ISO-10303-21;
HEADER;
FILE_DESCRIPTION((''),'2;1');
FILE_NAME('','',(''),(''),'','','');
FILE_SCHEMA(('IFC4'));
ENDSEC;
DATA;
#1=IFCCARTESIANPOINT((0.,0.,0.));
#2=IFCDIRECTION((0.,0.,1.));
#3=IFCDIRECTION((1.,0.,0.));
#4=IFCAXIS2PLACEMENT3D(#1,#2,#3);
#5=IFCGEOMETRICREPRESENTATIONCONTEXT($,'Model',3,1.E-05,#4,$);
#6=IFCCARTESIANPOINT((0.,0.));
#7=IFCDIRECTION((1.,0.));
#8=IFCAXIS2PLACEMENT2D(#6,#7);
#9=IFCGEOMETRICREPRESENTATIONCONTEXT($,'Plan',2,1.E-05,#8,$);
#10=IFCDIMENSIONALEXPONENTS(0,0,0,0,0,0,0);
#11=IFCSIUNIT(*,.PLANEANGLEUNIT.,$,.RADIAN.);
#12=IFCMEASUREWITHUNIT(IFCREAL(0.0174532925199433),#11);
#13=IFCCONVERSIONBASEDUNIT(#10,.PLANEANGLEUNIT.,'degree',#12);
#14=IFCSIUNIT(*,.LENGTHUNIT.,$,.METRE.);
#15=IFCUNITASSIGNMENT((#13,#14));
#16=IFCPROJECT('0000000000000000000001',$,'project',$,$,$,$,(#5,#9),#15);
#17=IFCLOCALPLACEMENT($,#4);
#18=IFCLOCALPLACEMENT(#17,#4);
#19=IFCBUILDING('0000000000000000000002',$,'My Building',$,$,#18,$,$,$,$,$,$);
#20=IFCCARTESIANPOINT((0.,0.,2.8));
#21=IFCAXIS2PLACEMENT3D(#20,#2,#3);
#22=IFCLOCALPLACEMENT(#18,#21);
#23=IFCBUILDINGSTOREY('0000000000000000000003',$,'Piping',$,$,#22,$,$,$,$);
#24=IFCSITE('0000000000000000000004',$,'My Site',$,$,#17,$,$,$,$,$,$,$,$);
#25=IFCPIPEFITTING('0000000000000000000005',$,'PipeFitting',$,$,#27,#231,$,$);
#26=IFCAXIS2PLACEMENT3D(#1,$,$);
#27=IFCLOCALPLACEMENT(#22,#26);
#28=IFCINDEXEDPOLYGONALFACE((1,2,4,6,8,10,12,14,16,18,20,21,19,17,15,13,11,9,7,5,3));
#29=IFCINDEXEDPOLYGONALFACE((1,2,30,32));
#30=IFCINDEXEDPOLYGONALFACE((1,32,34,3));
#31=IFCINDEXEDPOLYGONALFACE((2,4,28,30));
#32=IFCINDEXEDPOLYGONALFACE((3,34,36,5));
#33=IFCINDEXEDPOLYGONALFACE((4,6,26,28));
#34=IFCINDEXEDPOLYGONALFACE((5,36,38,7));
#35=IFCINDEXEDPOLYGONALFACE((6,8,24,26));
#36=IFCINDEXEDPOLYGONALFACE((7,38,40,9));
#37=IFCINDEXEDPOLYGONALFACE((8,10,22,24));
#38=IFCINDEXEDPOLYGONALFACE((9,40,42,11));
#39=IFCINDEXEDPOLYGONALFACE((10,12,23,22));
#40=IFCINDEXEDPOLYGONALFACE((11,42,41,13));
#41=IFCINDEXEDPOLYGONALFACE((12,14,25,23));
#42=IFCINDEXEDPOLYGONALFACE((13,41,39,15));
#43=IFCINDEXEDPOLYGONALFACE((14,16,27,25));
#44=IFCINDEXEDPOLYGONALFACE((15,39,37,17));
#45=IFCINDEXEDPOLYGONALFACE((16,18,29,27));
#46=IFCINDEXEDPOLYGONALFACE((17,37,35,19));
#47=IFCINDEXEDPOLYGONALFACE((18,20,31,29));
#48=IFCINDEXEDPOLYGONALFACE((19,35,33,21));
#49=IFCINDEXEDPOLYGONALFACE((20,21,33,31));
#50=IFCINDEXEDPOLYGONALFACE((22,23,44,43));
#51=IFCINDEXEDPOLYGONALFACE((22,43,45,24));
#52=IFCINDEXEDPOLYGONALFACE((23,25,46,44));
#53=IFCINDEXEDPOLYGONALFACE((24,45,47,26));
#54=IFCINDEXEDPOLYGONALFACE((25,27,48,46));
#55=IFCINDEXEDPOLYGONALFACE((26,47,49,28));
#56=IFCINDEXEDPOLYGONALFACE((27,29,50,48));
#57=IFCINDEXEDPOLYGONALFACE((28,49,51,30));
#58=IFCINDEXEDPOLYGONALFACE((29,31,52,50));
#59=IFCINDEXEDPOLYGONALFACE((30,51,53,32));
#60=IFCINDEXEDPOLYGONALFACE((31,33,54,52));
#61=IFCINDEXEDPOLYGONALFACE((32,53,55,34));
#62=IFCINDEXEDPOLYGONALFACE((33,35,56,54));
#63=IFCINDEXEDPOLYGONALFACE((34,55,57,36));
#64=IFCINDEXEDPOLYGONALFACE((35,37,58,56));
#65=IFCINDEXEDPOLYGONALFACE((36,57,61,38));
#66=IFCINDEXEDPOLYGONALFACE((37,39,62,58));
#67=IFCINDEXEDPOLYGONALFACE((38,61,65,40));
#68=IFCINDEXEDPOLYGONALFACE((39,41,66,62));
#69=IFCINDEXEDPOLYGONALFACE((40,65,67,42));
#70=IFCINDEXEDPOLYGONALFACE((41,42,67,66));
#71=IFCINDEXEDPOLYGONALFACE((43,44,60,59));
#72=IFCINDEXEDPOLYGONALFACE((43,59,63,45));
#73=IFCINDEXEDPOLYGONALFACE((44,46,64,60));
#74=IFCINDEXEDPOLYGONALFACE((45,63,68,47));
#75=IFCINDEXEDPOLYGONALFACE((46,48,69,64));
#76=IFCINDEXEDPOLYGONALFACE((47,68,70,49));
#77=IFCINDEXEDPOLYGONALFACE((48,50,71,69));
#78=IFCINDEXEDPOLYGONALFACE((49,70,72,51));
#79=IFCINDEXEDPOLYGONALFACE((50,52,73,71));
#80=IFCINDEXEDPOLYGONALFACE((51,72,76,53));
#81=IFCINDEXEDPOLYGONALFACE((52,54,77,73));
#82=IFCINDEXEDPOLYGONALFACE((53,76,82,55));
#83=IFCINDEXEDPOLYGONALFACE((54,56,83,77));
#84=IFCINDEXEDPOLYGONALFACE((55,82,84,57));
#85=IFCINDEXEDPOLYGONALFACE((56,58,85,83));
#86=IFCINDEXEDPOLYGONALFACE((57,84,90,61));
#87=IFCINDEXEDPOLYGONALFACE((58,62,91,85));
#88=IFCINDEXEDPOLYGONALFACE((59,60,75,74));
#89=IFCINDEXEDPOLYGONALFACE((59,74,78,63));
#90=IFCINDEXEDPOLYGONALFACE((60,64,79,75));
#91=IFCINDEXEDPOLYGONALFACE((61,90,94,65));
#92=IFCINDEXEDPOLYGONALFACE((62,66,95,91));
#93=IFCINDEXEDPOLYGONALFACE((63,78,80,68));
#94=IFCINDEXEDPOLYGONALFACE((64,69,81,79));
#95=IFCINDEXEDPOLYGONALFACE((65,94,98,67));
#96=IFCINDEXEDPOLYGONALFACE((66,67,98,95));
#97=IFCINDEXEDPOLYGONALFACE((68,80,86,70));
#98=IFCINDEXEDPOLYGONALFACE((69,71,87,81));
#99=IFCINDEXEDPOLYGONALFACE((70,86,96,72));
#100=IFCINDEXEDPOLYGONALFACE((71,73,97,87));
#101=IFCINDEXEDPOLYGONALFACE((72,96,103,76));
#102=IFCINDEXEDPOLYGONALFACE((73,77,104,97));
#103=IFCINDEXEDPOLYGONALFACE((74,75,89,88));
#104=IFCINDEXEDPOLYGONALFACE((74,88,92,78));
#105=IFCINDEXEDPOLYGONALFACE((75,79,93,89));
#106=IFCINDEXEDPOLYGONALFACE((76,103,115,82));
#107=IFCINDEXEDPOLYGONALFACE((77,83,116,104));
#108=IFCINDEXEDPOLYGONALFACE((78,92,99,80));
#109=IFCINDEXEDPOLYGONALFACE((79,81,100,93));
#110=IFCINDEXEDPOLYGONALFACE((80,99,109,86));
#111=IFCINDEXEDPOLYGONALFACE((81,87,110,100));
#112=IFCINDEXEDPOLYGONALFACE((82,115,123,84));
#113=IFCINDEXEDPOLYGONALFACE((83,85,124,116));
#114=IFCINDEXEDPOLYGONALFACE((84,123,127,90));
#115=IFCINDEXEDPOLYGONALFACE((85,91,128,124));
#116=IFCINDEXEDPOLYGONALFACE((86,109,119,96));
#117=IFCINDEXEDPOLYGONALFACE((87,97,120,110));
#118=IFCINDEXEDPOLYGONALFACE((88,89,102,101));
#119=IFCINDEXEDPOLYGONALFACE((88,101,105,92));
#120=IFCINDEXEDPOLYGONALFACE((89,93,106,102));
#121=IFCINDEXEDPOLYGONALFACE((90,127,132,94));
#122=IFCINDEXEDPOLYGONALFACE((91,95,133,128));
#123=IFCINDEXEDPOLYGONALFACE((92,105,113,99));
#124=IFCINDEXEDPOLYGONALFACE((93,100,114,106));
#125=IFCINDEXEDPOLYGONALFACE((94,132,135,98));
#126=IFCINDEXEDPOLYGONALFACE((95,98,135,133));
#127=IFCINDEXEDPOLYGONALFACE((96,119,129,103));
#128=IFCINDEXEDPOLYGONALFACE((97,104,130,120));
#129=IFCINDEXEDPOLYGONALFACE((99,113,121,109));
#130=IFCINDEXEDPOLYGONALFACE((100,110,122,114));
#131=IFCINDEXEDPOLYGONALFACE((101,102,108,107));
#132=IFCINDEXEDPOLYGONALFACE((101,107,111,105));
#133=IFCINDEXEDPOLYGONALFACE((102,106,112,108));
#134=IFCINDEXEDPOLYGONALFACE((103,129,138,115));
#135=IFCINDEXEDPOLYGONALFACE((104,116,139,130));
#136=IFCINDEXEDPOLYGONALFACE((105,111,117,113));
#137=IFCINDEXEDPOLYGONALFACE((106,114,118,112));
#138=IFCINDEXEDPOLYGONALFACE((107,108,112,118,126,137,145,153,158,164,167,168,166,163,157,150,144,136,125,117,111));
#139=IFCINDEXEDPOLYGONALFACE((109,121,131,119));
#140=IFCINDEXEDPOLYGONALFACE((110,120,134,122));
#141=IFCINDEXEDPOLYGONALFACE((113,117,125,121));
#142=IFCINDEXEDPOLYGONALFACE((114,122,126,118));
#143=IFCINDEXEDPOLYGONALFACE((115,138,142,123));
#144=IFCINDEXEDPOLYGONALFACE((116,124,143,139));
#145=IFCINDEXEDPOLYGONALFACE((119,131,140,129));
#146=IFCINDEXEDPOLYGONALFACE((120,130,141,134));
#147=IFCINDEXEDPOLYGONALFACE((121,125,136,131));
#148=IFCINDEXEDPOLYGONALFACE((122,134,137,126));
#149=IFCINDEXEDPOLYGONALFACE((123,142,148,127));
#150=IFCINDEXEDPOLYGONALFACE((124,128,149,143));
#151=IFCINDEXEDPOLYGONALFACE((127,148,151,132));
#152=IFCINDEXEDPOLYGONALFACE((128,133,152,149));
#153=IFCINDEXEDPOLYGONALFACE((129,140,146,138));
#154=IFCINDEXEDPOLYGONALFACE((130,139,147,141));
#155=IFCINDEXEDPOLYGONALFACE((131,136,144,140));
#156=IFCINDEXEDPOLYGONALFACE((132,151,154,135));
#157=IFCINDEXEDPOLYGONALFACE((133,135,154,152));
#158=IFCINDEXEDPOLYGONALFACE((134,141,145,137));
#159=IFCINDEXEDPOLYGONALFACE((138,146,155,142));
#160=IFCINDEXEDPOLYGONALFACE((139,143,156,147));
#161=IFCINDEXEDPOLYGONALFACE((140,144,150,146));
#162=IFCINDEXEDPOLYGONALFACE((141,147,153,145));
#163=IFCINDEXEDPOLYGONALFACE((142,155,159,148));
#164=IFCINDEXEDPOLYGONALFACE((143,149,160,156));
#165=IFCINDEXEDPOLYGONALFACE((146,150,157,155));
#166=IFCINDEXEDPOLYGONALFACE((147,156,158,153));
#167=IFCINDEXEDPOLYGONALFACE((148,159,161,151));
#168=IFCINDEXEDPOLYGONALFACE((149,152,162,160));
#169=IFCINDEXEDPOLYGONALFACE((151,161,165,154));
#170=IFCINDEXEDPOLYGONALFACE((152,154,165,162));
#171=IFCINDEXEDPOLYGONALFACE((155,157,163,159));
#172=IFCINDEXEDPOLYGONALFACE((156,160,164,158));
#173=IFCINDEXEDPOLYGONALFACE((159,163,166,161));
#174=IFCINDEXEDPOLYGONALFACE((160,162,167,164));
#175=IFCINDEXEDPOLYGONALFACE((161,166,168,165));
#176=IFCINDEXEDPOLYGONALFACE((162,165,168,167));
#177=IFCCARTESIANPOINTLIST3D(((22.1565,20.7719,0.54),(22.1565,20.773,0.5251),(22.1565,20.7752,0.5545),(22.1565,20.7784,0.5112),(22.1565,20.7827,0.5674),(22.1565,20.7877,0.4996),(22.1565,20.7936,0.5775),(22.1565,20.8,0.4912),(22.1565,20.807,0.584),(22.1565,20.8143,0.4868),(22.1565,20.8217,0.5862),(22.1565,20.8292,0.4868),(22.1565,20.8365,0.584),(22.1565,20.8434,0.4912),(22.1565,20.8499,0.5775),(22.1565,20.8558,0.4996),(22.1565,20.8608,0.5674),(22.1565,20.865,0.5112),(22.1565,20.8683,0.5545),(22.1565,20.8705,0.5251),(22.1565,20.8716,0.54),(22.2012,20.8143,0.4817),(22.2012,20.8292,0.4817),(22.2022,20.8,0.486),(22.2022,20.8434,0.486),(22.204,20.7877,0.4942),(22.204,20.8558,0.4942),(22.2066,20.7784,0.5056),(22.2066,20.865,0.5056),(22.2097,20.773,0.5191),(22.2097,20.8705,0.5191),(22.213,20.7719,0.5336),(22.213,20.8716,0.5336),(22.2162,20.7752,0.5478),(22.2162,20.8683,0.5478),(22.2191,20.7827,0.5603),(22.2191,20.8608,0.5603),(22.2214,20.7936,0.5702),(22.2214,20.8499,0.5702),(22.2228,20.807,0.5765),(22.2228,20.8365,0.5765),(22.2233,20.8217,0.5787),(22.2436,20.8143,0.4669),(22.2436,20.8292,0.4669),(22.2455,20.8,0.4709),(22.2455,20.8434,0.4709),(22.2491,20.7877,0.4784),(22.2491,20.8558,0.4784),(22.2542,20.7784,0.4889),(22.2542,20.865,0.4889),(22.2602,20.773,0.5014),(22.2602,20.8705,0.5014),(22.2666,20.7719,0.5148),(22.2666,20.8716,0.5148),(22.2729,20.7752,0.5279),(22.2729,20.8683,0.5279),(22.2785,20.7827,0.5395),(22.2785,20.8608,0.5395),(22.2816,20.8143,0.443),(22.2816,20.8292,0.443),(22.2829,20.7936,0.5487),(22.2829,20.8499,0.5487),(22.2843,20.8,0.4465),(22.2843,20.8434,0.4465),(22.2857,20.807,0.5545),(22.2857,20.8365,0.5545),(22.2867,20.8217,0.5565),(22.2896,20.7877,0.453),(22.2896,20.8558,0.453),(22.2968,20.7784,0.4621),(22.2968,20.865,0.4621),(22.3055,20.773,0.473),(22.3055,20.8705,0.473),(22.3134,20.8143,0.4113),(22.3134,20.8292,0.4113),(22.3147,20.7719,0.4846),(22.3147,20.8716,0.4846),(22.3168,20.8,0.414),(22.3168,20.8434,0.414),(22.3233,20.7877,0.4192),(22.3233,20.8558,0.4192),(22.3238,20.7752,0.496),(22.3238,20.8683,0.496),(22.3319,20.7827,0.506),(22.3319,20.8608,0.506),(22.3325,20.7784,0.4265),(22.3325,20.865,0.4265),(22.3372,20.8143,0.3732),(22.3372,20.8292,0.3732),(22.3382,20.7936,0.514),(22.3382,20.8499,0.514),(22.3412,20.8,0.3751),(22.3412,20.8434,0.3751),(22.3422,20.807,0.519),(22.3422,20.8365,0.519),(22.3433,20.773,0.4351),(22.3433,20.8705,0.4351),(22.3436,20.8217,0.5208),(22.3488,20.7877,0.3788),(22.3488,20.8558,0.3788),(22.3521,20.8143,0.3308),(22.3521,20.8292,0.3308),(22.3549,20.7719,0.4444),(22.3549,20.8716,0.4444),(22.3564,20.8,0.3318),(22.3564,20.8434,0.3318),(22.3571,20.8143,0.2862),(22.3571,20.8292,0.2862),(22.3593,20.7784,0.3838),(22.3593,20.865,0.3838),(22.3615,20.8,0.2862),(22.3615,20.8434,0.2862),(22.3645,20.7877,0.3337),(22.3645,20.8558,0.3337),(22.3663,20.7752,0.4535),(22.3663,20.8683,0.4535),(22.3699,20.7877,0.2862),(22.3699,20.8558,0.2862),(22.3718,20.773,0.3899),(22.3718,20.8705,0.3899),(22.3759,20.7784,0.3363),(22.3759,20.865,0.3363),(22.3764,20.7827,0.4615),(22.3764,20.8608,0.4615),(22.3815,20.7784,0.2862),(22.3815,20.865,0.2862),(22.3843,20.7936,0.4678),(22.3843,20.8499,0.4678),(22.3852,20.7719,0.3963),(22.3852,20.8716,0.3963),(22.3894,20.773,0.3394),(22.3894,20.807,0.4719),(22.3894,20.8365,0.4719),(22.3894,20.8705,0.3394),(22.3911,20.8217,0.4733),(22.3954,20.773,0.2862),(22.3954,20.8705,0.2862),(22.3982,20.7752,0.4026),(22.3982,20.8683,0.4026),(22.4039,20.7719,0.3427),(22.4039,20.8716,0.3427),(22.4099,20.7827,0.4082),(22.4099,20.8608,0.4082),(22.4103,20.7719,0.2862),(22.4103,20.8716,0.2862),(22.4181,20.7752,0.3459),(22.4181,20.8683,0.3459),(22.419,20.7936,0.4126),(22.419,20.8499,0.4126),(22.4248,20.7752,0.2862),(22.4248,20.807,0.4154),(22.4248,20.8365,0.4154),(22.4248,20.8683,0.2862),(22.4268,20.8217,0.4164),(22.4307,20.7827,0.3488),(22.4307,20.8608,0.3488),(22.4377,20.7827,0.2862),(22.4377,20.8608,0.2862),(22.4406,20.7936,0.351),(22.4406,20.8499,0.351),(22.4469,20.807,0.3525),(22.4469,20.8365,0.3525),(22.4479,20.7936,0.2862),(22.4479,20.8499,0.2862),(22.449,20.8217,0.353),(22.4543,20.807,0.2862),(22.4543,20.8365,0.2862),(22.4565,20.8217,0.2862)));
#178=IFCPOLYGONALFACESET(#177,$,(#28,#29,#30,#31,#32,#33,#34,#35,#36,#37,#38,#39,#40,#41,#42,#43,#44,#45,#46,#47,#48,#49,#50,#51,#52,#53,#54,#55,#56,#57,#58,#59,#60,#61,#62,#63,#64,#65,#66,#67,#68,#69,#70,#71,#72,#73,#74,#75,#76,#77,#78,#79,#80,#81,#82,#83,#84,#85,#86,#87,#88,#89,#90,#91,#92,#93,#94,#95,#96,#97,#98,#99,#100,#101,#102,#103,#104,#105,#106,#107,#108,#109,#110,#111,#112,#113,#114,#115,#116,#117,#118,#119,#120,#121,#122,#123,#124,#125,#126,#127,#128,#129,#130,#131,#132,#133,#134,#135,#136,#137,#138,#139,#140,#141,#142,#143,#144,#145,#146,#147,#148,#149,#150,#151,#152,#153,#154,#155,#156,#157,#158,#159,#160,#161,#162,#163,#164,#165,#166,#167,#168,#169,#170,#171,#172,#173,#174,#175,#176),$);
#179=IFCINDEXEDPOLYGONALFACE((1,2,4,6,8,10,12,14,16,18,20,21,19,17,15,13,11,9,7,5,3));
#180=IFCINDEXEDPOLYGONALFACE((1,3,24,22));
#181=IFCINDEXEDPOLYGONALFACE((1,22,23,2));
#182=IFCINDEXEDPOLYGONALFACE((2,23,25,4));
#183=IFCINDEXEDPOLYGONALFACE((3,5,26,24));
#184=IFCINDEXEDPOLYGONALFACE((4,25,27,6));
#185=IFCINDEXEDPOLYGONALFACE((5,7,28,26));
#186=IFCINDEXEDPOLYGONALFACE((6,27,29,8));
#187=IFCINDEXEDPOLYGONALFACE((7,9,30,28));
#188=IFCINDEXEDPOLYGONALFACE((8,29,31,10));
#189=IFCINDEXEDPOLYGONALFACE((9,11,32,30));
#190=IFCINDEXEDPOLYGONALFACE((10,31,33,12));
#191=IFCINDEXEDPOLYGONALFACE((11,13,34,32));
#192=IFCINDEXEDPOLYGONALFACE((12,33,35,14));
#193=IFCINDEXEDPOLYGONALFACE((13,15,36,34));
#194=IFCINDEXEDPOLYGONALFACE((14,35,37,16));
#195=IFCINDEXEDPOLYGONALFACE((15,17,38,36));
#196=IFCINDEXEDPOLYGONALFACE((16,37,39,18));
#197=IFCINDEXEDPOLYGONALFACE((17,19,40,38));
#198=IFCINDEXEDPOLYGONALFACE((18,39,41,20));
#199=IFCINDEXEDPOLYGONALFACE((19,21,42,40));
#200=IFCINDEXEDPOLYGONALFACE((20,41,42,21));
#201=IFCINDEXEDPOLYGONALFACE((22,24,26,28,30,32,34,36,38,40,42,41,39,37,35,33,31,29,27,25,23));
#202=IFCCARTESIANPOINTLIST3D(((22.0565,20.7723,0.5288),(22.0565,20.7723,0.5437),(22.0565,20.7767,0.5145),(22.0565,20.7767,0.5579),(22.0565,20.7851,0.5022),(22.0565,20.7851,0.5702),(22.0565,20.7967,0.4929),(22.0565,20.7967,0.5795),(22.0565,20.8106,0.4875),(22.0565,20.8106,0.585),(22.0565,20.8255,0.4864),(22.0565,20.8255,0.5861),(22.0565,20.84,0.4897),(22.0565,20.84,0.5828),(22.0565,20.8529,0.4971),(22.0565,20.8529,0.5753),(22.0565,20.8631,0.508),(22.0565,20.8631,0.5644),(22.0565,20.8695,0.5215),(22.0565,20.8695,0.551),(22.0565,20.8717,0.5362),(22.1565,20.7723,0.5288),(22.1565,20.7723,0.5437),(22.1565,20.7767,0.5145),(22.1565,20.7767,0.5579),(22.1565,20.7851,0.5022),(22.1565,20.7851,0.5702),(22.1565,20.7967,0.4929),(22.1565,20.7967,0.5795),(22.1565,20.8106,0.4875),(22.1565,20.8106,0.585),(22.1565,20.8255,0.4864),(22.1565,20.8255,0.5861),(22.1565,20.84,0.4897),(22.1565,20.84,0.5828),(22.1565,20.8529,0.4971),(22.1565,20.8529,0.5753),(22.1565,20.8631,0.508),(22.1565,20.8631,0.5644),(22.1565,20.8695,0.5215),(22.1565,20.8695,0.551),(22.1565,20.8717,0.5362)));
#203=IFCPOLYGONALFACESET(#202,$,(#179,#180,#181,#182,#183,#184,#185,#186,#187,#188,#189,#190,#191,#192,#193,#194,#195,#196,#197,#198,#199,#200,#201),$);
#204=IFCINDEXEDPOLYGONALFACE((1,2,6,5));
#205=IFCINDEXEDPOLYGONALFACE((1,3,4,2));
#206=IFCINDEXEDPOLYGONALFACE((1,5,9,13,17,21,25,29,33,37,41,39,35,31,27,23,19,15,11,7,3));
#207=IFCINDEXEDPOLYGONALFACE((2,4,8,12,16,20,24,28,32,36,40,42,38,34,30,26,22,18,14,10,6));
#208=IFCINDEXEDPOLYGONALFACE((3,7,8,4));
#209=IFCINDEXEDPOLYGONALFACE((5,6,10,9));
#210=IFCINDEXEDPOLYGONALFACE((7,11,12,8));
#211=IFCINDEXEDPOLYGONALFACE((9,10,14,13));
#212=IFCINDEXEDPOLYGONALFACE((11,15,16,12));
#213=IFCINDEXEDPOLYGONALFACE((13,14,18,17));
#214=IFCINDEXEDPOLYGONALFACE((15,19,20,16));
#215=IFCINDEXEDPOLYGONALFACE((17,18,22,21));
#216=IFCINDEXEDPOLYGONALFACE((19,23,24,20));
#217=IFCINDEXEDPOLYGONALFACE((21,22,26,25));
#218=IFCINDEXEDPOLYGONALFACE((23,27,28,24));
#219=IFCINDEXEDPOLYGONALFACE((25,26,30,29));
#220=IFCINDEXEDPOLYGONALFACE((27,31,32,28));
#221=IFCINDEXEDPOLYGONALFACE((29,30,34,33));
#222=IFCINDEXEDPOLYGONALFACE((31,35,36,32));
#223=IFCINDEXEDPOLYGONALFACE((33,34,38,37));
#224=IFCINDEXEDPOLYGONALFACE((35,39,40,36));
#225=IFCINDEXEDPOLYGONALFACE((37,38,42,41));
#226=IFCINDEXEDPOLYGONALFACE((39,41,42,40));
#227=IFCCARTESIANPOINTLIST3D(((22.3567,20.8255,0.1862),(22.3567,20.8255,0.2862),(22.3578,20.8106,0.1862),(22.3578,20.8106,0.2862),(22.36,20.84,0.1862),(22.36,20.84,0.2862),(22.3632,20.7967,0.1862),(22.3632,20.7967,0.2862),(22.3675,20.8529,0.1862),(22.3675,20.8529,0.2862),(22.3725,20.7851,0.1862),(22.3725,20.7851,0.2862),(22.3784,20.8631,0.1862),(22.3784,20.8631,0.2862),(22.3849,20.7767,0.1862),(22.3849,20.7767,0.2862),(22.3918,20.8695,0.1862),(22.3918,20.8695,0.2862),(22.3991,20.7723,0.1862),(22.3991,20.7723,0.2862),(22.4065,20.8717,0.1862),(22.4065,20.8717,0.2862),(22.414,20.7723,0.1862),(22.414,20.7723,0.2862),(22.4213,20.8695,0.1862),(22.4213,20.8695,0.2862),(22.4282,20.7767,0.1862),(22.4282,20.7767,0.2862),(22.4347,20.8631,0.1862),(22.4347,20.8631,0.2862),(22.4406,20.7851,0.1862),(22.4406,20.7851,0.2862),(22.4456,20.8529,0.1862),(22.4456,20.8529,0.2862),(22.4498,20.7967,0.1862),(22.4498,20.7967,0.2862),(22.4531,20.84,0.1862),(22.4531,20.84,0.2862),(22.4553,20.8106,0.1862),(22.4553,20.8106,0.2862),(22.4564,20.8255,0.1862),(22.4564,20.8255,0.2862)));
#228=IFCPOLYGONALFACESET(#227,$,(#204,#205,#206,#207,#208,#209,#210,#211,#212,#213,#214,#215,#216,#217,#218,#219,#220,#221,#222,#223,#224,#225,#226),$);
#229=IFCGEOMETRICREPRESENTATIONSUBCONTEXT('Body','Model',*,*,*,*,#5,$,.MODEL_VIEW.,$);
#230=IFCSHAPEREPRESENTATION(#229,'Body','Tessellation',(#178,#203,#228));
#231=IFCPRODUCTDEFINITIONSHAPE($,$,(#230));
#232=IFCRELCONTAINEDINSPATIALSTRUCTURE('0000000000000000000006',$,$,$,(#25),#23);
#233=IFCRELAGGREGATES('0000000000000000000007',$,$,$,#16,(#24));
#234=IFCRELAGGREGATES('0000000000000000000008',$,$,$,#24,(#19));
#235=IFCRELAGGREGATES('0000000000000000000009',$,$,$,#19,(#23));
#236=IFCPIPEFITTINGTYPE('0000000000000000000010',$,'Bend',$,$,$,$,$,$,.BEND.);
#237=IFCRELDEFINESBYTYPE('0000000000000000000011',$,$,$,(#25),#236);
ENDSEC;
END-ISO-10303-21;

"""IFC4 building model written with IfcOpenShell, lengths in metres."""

from ifc_helpers import new_model, entity, si_unit, converted_unit, frame, origin_with_axes, origin_2d_with_axis, place, context, subcontext, project, spatial, circle, extrude, source, transform, mapped, type_object, type_shapes, element, save


model = new_model("IFC4")

# Units and contexts
model_context = context("Model", 3, precision=1e-05, world=origin_with_axes())
plan_context = context("Plan", 2, precision=1e-05, world=origin_2d_with_axis())
body_context = subcontext(model_context, "Body", "Model", "MODEL_VIEW")
ifc_project = project(units=[converted_unit("PLANEANGLEUNIT", "degree", entity("IfcReal", 0.0174532925199433), si_unit("PLANEANGLEUNIT", "RADIAN"), dimensions=[0, 0, 0, 0, 0, 0, 0]), si_unit("LENGTHUNIT", "METRE")], contexts=[model_context, plan_context])

# Site, building, storey
site_placement = place(None, origin_with_axes())
site = spatial("IfcSite", under=ifc_project, at=site_placement, Name="My Site")
building_placement = place(site_placement, origin_with_axes())
building = spatial("IfcBuilding", under=site, at=building_placement, Name="My Building")
storey_placement = place(building_placement, frame((0.0, 0.0, 2.8), z_axis=(0.0, 0.0, 1.0), x_axis=(1.0, 0.0, 0.0)))
storey = spatial("IfcBuildingStorey", under=building, at=storey_placement, Name="Piping")

# Pipe fitting
pipe_fitting_type_1 = type_object("IfcPipeFittingType", Name="Bend", PredefinedType="BEND")
shared_shape_1 = source(origin_with_axes(), body_context, "Body", "SolidModel", [
    entity("IfcSweptDiskSolid", entity("IfcIndexedPolyCurve", entity("IfcCartesianPointList3D", [[0.0, 0.0, 0.1], [0.0, -0.0732, 0.2768], [0.0, -0.25, 0.35]]), [entity("IfcArcIndex", [1, 2, 3])]), 0.05),
    extrude(circle(Radius=0.05), origin_with_axes(), (0.0, 0.0, 1.0), 0.1),
    extrude(circle(Radius=0.05), frame((0.0, -0.25, 0.35), z_axis=(0.0, -1.0, 0.0), x_axis=(1.0, 0.0, 0.0)), (0.0, 0.0, 1.0), 0.1),
])
type_shapes(pipe_fitting_type_1, [shared_shape_1])
for number, where, z_axis, x_axis, name in (
    (1, (22.0565, 20.8217, 0.5362), (1.0, 0.0, 0.0), (0.0, 1.0, 0.0), "PipeFitting"),
):
    element("IfcPipeFitting", number, at=place(storey_placement, frame(where, z_axis=z_axis, x_axis=x_axis)), inside=storey, type_object=pipe_fitting_type_1, Name=name, context=body_context, shape_type="MappedRepresentation", body=[
        mapped(shared_shape_1, transform((0.0, 0.0, 0.0), x_axis=(1.0, 0.0, 0.0), y_axis=(0.0, 1.0, 0.0), z_axis=(0.0, 0.0, 1.0), scale=1.0)),
    ])

save(model, "model.ifc")
